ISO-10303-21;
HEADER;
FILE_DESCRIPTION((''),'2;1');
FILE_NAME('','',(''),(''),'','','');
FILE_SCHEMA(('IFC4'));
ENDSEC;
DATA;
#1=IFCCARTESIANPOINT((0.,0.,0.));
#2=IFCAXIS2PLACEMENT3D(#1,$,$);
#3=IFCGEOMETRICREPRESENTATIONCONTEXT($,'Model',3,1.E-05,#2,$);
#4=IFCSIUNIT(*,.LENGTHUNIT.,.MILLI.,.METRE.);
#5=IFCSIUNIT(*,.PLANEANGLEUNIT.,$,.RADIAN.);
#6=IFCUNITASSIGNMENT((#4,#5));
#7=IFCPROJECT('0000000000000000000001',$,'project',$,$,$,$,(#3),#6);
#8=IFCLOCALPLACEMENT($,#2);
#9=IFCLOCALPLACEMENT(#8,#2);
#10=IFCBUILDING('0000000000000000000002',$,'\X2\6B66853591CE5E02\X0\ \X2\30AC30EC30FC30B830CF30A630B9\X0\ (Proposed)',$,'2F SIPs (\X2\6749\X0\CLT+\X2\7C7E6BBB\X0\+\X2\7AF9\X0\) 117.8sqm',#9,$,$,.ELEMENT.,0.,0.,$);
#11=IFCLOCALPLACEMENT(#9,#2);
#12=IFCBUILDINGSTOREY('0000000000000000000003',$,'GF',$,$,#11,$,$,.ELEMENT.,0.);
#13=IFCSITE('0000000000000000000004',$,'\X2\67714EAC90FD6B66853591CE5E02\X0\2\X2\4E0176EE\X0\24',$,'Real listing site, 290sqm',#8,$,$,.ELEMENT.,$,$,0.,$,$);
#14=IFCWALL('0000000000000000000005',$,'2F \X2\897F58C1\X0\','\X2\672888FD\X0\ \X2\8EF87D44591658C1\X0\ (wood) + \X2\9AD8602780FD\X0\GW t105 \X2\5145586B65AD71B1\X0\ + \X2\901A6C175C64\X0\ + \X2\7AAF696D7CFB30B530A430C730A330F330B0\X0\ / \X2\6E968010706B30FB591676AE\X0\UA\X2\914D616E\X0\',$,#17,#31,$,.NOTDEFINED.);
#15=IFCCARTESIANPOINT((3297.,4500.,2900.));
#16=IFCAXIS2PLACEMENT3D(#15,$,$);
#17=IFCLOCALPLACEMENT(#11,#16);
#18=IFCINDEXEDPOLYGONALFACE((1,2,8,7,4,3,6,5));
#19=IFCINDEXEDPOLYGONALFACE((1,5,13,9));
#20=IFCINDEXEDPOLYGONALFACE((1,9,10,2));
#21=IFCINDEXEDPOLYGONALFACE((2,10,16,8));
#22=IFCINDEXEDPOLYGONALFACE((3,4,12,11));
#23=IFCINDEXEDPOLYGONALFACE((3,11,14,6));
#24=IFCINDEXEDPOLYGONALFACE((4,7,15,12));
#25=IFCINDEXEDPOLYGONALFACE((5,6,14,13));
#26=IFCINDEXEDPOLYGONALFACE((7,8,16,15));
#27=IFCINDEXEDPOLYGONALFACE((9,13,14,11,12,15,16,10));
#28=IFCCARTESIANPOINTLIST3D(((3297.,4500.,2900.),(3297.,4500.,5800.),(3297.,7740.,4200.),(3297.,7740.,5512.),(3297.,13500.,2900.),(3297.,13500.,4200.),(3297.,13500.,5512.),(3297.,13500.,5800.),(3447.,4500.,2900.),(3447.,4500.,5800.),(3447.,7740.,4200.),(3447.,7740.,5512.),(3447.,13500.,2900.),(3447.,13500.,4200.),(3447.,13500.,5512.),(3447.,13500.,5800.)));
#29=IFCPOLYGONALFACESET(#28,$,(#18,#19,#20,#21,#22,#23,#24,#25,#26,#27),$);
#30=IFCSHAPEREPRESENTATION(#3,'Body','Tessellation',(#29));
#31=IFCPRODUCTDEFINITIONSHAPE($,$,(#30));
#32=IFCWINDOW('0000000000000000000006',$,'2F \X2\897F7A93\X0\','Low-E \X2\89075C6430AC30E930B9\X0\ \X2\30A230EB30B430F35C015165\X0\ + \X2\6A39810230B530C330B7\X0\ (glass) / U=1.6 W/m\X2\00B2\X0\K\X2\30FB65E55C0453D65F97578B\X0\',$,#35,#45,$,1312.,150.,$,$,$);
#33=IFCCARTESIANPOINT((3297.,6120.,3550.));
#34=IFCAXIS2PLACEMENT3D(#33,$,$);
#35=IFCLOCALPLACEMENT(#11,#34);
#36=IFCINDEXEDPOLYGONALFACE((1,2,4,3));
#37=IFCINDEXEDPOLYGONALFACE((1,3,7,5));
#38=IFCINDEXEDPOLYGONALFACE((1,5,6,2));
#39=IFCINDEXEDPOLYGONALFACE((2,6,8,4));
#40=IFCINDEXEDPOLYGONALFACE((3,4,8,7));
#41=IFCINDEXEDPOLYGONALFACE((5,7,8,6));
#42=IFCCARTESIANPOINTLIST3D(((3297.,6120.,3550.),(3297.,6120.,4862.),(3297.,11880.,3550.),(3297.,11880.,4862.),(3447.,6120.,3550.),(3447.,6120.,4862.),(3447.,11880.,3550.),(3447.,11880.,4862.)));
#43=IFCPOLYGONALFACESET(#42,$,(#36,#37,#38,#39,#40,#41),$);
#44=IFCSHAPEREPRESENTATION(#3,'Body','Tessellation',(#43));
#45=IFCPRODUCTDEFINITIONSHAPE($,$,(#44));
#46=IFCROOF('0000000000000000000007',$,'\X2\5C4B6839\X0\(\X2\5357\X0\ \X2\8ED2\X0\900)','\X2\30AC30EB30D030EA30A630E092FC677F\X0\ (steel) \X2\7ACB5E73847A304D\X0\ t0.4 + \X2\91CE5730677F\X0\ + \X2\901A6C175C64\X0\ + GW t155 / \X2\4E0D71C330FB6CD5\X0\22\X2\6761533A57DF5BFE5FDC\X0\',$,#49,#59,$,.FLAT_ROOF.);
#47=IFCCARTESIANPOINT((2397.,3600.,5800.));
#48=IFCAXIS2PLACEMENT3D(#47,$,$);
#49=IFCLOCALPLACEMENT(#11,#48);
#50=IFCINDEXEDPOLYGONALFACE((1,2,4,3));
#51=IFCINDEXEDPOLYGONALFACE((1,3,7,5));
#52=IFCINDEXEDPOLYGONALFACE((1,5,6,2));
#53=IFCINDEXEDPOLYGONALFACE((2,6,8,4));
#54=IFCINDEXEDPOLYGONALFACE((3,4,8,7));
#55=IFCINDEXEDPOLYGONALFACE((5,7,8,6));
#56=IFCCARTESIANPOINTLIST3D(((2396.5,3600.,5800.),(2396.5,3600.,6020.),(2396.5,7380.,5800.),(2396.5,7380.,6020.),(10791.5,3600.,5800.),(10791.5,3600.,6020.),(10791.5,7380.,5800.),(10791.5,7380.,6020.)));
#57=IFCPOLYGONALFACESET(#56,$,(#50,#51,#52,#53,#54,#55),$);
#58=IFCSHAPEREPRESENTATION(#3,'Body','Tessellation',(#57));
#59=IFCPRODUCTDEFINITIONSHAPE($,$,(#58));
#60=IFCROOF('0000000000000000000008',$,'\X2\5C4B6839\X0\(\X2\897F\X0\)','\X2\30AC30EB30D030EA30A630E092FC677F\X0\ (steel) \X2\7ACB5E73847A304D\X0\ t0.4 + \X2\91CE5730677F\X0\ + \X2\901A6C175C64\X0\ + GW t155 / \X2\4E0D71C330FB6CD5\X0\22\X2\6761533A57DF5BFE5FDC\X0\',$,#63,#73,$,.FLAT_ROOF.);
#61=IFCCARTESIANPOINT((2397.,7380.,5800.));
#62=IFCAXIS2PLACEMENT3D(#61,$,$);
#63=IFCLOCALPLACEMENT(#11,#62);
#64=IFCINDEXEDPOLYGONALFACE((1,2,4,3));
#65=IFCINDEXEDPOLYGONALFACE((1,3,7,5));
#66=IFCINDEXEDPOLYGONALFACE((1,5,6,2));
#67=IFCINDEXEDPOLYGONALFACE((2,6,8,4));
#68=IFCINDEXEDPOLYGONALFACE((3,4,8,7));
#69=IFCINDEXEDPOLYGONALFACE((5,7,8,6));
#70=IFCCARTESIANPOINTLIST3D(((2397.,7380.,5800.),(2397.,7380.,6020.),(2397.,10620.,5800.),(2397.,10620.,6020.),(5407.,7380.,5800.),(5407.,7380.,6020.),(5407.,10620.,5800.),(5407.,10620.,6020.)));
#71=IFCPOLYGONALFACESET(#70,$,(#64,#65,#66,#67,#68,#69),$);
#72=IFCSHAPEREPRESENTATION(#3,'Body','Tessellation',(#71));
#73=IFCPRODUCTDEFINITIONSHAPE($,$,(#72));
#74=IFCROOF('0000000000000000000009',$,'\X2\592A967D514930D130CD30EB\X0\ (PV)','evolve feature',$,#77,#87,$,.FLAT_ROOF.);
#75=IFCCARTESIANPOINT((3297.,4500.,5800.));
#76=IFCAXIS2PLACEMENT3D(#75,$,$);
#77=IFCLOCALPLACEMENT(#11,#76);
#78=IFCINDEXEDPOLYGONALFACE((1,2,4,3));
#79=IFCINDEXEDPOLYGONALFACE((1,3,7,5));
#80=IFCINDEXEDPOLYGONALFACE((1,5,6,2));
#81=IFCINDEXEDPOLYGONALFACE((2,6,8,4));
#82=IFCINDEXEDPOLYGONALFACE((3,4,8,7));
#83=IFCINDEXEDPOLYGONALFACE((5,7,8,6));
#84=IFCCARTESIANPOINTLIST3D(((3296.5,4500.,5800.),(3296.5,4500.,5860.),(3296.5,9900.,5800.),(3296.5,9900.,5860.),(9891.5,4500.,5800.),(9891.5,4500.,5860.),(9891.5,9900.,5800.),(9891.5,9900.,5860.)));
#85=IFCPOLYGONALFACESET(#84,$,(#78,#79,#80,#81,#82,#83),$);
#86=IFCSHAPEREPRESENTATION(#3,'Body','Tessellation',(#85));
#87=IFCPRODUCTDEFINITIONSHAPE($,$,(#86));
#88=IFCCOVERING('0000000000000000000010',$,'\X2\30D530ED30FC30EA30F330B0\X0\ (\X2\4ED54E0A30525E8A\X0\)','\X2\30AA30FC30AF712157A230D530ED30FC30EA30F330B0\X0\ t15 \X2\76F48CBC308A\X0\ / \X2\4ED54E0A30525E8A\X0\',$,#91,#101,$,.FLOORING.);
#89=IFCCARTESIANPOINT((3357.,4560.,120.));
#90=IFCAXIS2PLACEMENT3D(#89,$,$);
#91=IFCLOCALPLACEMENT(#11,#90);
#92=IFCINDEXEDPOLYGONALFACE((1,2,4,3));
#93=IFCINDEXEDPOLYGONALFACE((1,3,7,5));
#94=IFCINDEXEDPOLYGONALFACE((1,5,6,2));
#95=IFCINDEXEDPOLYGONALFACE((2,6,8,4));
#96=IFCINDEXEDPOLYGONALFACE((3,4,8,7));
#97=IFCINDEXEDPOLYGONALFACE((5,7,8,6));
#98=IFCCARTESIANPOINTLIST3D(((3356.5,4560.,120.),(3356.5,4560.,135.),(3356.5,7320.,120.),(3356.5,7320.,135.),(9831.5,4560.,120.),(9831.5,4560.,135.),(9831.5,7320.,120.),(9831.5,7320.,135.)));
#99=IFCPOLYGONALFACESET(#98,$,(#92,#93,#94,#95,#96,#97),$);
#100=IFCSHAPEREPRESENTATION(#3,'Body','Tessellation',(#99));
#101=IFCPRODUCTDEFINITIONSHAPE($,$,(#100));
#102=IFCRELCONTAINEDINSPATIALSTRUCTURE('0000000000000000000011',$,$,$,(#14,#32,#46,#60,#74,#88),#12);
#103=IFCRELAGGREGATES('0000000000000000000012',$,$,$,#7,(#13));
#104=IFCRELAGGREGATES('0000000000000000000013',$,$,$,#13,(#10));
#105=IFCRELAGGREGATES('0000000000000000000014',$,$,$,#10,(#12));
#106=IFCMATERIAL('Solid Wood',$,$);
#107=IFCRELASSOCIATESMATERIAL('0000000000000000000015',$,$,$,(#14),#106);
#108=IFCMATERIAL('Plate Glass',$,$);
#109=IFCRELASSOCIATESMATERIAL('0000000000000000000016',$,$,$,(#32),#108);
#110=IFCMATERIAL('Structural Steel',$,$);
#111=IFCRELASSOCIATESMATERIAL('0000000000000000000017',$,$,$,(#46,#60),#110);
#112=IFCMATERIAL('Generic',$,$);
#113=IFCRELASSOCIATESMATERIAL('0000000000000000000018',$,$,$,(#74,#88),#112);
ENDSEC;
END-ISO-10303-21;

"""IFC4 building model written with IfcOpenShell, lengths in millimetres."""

from ifc_helpers import new_model, si_unit, frame, frame_2d, origin, place, context, project, spatial, rectangle, extrude, material, element, fill, save


model = new_model("IFC4")

# Units and contexts
model_context = context("Model", 3, precision=1e-05, world=origin())
ifc_project = project(units=[si_unit("LENGTHUNIT", "METRE", prefix="MILLI"), si_unit("PLANEANGLEUNIT", "RADIAN")], contexts=[model_context])

# Site, building, storey
site_placement = place(None, origin())
site = spatial("IfcSite", under=ifc_project, at=site_placement, Name="東京都武蔵野市2丁目24", ObjectType="Real listing site, 290sqm", CompositionType="ELEMENT", RefElevation=0.0)
building_placement = place(site_placement, origin())
building = spatial("IfcBuilding", under=site, at=building_placement, Name="武蔵野市 ガレージハウス (Proposed)", ObjectType="2F SIPs (杉CLT+籾殻+竹) 117.8sqm", CompositionType="ELEMENT", ElevationOfRefHeight=0.0, ElevationOfTerrain=0.0)
storey_placement = place(building_placement, origin())
storey = spatial("IfcBuildingStorey", under=building, at=storey_placement, Name="GF", CompositionType="ELEMENT", Elevation=0.0)

# Shared definitions
ifc_material_1 = material(Name="Solid Wood")
ifc_material_2 = material(Name="Generic")

# Shared definitions
ifc_material_3 = material(Name="Plate Glass")

# Wall, opening, window
wall_1_placement = place(storey_placement, frame((3297.0, 4500.0, 2900.0)))
wall_1 = element("IfcWall", 1, at=wall_1_placement, inside=storey, material=ifc_material_1, Name="2F 西壁", Description="木製 軸組外壁 (wood) + 高性能GW t105 充填断熱 + 通気層 + 窯業系サイディング / 準耐火・外皮UA配慮", PredefinedType="NOTDEFINED", context=model_context, shape_type="SweptSolid", body=[
    extrude(rectangle(XDim=150.0, YDim=9000.0, at=frame_2d((75.0, 4500.0))), frame((3297.0, 4500.0, 2900.0)), (0.0, 0.0, 1.0), 2900.0),
])
opening_1_placement = place(storey_placement, frame((3297.0, 6120.0, 3550.0)))
opening_1 = element("IfcOpeningElement", 2, at=opening_1_placement, cuts=wall_1, PredefinedType="NOTDEFINED", context=model_context, shape_type="SweptSolid", body=[
    extrude(rectangle(XDim=150.0, YDim=5760.0, at=frame_2d((75.0, 2880.0))), frame((3297.0, 6120.0, 3550.0)), (0.0, 0.0, 1.0), 1312.0),
])
window_1_placement = place(storey_placement, frame((3297.0, 6120.0, 3550.0)))
window_1 = element("IfcWindow", 3, at=window_1_placement, inside=storey, material=ifc_material_3, Name="2F 西窓", Description="Low-E 複層ガラス アルゴン封入 + 樹脂サッシ (glass) / U=1.6 W/m²K・日射取得型", OverallHeight=1312.0, OverallWidth=150.0, context=model_context, shape_type="SweptSolid", body=[
    extrude(rectangle(XDim=150.0, YDim=5760.0, at=frame_2d((75.0, 2880.0))), frame((3297.0, 6120.0, 3550.0)), (0.0, 0.0, 1.0), 1312.0),
])
fill(opening_1, window_1)

# Roofs
ifc_material_4 = material(Name="Structural Steel")
roof_1_placement = place(storey_placement, frame((2397.0, 3600.0, 5800.0)))
element("IfcRoof", 4, at=roof_1_placement, inside=storey, material=ifc_material_4, Name="屋根(南 軒900)", Description="ガルバリウム鋼板 (steel) 立平葺き t0.4 + 野地板 + 通気層 + GW t155 / 不燃・法22条区域対応", PredefinedType="FLAT_ROOF", context=model_context, shape_type="SweptSolid", body=[
    extrude(rectangle(XDim=8395.0, YDim=3780.0, at=frame_2d((4197.0, 1890.0))), frame((2397.0, 3600.0, 5800.0)), (0.0, 0.0, 1.0), 220.0),
])
roof_2_placement = place(storey_placement, frame((2397.0, 7380.0, 5800.0)))
element("IfcRoof", 5, at=roof_2_placement, inside=storey, material=ifc_material_4, Name="屋根(西)", Description="ガルバリウム鋼板 (steel) 立平葺き t0.4 + 野地板 + 通気層 + GW t155 / 不燃・法22条区域対応", PredefinedType="FLAT_ROOF", context=model_context, shape_type="SweptSolid", body=[
    extrude(rectangle(XDim=3010.0, YDim=3240.0, at=frame_2d((1505.0, 1620.0))), frame((2397.0, 7380.0, 5800.0)), (0.0, 0.0, 1.0), 220.0),
])
roof_3_placement = place(storey_placement, frame((3297.0, 4500.0, 5800.0)))
element("IfcRoof", 6, at=roof_3_placement, inside=storey, material=ifc_material_2, Name="太陽光パネル (PV)", Description="evolve feature", PredefinedType="FLAT_ROOF", context=model_context, shape_type="SweptSolid", body=[
    extrude(rectangle(XDim=6595.0, YDim=5400.0, at=frame_2d((3297.0, 2700.0))), frame((3297.0, 4500.0, 5800.0)), (0.0, 0.0, 1.0), 60.0),
])

# Covering
covering_placement = place(storey_placement, frame((3357.0, 4560.0, 120.0)))
element("IfcCovering", 7, at=covering_placement, inside=storey, material=ifc_material_2, Name="フローリング (仕上げ床)", Description="オーク無垢フローリング t15 直貼り / 仕上げ床", PredefinedType="FLOORING", context=model_context, shape_type="SweptSolid", body=[
    extrude(rectangle(XDim=6475.0, YDim=2760.0, at=frame_2d((3237.0, 1380.0))), frame((3357.0, 4560.0, 120.0)), (0.0, 0.0, 1.0), 15.0),
])

save(model, "model.ifc")
